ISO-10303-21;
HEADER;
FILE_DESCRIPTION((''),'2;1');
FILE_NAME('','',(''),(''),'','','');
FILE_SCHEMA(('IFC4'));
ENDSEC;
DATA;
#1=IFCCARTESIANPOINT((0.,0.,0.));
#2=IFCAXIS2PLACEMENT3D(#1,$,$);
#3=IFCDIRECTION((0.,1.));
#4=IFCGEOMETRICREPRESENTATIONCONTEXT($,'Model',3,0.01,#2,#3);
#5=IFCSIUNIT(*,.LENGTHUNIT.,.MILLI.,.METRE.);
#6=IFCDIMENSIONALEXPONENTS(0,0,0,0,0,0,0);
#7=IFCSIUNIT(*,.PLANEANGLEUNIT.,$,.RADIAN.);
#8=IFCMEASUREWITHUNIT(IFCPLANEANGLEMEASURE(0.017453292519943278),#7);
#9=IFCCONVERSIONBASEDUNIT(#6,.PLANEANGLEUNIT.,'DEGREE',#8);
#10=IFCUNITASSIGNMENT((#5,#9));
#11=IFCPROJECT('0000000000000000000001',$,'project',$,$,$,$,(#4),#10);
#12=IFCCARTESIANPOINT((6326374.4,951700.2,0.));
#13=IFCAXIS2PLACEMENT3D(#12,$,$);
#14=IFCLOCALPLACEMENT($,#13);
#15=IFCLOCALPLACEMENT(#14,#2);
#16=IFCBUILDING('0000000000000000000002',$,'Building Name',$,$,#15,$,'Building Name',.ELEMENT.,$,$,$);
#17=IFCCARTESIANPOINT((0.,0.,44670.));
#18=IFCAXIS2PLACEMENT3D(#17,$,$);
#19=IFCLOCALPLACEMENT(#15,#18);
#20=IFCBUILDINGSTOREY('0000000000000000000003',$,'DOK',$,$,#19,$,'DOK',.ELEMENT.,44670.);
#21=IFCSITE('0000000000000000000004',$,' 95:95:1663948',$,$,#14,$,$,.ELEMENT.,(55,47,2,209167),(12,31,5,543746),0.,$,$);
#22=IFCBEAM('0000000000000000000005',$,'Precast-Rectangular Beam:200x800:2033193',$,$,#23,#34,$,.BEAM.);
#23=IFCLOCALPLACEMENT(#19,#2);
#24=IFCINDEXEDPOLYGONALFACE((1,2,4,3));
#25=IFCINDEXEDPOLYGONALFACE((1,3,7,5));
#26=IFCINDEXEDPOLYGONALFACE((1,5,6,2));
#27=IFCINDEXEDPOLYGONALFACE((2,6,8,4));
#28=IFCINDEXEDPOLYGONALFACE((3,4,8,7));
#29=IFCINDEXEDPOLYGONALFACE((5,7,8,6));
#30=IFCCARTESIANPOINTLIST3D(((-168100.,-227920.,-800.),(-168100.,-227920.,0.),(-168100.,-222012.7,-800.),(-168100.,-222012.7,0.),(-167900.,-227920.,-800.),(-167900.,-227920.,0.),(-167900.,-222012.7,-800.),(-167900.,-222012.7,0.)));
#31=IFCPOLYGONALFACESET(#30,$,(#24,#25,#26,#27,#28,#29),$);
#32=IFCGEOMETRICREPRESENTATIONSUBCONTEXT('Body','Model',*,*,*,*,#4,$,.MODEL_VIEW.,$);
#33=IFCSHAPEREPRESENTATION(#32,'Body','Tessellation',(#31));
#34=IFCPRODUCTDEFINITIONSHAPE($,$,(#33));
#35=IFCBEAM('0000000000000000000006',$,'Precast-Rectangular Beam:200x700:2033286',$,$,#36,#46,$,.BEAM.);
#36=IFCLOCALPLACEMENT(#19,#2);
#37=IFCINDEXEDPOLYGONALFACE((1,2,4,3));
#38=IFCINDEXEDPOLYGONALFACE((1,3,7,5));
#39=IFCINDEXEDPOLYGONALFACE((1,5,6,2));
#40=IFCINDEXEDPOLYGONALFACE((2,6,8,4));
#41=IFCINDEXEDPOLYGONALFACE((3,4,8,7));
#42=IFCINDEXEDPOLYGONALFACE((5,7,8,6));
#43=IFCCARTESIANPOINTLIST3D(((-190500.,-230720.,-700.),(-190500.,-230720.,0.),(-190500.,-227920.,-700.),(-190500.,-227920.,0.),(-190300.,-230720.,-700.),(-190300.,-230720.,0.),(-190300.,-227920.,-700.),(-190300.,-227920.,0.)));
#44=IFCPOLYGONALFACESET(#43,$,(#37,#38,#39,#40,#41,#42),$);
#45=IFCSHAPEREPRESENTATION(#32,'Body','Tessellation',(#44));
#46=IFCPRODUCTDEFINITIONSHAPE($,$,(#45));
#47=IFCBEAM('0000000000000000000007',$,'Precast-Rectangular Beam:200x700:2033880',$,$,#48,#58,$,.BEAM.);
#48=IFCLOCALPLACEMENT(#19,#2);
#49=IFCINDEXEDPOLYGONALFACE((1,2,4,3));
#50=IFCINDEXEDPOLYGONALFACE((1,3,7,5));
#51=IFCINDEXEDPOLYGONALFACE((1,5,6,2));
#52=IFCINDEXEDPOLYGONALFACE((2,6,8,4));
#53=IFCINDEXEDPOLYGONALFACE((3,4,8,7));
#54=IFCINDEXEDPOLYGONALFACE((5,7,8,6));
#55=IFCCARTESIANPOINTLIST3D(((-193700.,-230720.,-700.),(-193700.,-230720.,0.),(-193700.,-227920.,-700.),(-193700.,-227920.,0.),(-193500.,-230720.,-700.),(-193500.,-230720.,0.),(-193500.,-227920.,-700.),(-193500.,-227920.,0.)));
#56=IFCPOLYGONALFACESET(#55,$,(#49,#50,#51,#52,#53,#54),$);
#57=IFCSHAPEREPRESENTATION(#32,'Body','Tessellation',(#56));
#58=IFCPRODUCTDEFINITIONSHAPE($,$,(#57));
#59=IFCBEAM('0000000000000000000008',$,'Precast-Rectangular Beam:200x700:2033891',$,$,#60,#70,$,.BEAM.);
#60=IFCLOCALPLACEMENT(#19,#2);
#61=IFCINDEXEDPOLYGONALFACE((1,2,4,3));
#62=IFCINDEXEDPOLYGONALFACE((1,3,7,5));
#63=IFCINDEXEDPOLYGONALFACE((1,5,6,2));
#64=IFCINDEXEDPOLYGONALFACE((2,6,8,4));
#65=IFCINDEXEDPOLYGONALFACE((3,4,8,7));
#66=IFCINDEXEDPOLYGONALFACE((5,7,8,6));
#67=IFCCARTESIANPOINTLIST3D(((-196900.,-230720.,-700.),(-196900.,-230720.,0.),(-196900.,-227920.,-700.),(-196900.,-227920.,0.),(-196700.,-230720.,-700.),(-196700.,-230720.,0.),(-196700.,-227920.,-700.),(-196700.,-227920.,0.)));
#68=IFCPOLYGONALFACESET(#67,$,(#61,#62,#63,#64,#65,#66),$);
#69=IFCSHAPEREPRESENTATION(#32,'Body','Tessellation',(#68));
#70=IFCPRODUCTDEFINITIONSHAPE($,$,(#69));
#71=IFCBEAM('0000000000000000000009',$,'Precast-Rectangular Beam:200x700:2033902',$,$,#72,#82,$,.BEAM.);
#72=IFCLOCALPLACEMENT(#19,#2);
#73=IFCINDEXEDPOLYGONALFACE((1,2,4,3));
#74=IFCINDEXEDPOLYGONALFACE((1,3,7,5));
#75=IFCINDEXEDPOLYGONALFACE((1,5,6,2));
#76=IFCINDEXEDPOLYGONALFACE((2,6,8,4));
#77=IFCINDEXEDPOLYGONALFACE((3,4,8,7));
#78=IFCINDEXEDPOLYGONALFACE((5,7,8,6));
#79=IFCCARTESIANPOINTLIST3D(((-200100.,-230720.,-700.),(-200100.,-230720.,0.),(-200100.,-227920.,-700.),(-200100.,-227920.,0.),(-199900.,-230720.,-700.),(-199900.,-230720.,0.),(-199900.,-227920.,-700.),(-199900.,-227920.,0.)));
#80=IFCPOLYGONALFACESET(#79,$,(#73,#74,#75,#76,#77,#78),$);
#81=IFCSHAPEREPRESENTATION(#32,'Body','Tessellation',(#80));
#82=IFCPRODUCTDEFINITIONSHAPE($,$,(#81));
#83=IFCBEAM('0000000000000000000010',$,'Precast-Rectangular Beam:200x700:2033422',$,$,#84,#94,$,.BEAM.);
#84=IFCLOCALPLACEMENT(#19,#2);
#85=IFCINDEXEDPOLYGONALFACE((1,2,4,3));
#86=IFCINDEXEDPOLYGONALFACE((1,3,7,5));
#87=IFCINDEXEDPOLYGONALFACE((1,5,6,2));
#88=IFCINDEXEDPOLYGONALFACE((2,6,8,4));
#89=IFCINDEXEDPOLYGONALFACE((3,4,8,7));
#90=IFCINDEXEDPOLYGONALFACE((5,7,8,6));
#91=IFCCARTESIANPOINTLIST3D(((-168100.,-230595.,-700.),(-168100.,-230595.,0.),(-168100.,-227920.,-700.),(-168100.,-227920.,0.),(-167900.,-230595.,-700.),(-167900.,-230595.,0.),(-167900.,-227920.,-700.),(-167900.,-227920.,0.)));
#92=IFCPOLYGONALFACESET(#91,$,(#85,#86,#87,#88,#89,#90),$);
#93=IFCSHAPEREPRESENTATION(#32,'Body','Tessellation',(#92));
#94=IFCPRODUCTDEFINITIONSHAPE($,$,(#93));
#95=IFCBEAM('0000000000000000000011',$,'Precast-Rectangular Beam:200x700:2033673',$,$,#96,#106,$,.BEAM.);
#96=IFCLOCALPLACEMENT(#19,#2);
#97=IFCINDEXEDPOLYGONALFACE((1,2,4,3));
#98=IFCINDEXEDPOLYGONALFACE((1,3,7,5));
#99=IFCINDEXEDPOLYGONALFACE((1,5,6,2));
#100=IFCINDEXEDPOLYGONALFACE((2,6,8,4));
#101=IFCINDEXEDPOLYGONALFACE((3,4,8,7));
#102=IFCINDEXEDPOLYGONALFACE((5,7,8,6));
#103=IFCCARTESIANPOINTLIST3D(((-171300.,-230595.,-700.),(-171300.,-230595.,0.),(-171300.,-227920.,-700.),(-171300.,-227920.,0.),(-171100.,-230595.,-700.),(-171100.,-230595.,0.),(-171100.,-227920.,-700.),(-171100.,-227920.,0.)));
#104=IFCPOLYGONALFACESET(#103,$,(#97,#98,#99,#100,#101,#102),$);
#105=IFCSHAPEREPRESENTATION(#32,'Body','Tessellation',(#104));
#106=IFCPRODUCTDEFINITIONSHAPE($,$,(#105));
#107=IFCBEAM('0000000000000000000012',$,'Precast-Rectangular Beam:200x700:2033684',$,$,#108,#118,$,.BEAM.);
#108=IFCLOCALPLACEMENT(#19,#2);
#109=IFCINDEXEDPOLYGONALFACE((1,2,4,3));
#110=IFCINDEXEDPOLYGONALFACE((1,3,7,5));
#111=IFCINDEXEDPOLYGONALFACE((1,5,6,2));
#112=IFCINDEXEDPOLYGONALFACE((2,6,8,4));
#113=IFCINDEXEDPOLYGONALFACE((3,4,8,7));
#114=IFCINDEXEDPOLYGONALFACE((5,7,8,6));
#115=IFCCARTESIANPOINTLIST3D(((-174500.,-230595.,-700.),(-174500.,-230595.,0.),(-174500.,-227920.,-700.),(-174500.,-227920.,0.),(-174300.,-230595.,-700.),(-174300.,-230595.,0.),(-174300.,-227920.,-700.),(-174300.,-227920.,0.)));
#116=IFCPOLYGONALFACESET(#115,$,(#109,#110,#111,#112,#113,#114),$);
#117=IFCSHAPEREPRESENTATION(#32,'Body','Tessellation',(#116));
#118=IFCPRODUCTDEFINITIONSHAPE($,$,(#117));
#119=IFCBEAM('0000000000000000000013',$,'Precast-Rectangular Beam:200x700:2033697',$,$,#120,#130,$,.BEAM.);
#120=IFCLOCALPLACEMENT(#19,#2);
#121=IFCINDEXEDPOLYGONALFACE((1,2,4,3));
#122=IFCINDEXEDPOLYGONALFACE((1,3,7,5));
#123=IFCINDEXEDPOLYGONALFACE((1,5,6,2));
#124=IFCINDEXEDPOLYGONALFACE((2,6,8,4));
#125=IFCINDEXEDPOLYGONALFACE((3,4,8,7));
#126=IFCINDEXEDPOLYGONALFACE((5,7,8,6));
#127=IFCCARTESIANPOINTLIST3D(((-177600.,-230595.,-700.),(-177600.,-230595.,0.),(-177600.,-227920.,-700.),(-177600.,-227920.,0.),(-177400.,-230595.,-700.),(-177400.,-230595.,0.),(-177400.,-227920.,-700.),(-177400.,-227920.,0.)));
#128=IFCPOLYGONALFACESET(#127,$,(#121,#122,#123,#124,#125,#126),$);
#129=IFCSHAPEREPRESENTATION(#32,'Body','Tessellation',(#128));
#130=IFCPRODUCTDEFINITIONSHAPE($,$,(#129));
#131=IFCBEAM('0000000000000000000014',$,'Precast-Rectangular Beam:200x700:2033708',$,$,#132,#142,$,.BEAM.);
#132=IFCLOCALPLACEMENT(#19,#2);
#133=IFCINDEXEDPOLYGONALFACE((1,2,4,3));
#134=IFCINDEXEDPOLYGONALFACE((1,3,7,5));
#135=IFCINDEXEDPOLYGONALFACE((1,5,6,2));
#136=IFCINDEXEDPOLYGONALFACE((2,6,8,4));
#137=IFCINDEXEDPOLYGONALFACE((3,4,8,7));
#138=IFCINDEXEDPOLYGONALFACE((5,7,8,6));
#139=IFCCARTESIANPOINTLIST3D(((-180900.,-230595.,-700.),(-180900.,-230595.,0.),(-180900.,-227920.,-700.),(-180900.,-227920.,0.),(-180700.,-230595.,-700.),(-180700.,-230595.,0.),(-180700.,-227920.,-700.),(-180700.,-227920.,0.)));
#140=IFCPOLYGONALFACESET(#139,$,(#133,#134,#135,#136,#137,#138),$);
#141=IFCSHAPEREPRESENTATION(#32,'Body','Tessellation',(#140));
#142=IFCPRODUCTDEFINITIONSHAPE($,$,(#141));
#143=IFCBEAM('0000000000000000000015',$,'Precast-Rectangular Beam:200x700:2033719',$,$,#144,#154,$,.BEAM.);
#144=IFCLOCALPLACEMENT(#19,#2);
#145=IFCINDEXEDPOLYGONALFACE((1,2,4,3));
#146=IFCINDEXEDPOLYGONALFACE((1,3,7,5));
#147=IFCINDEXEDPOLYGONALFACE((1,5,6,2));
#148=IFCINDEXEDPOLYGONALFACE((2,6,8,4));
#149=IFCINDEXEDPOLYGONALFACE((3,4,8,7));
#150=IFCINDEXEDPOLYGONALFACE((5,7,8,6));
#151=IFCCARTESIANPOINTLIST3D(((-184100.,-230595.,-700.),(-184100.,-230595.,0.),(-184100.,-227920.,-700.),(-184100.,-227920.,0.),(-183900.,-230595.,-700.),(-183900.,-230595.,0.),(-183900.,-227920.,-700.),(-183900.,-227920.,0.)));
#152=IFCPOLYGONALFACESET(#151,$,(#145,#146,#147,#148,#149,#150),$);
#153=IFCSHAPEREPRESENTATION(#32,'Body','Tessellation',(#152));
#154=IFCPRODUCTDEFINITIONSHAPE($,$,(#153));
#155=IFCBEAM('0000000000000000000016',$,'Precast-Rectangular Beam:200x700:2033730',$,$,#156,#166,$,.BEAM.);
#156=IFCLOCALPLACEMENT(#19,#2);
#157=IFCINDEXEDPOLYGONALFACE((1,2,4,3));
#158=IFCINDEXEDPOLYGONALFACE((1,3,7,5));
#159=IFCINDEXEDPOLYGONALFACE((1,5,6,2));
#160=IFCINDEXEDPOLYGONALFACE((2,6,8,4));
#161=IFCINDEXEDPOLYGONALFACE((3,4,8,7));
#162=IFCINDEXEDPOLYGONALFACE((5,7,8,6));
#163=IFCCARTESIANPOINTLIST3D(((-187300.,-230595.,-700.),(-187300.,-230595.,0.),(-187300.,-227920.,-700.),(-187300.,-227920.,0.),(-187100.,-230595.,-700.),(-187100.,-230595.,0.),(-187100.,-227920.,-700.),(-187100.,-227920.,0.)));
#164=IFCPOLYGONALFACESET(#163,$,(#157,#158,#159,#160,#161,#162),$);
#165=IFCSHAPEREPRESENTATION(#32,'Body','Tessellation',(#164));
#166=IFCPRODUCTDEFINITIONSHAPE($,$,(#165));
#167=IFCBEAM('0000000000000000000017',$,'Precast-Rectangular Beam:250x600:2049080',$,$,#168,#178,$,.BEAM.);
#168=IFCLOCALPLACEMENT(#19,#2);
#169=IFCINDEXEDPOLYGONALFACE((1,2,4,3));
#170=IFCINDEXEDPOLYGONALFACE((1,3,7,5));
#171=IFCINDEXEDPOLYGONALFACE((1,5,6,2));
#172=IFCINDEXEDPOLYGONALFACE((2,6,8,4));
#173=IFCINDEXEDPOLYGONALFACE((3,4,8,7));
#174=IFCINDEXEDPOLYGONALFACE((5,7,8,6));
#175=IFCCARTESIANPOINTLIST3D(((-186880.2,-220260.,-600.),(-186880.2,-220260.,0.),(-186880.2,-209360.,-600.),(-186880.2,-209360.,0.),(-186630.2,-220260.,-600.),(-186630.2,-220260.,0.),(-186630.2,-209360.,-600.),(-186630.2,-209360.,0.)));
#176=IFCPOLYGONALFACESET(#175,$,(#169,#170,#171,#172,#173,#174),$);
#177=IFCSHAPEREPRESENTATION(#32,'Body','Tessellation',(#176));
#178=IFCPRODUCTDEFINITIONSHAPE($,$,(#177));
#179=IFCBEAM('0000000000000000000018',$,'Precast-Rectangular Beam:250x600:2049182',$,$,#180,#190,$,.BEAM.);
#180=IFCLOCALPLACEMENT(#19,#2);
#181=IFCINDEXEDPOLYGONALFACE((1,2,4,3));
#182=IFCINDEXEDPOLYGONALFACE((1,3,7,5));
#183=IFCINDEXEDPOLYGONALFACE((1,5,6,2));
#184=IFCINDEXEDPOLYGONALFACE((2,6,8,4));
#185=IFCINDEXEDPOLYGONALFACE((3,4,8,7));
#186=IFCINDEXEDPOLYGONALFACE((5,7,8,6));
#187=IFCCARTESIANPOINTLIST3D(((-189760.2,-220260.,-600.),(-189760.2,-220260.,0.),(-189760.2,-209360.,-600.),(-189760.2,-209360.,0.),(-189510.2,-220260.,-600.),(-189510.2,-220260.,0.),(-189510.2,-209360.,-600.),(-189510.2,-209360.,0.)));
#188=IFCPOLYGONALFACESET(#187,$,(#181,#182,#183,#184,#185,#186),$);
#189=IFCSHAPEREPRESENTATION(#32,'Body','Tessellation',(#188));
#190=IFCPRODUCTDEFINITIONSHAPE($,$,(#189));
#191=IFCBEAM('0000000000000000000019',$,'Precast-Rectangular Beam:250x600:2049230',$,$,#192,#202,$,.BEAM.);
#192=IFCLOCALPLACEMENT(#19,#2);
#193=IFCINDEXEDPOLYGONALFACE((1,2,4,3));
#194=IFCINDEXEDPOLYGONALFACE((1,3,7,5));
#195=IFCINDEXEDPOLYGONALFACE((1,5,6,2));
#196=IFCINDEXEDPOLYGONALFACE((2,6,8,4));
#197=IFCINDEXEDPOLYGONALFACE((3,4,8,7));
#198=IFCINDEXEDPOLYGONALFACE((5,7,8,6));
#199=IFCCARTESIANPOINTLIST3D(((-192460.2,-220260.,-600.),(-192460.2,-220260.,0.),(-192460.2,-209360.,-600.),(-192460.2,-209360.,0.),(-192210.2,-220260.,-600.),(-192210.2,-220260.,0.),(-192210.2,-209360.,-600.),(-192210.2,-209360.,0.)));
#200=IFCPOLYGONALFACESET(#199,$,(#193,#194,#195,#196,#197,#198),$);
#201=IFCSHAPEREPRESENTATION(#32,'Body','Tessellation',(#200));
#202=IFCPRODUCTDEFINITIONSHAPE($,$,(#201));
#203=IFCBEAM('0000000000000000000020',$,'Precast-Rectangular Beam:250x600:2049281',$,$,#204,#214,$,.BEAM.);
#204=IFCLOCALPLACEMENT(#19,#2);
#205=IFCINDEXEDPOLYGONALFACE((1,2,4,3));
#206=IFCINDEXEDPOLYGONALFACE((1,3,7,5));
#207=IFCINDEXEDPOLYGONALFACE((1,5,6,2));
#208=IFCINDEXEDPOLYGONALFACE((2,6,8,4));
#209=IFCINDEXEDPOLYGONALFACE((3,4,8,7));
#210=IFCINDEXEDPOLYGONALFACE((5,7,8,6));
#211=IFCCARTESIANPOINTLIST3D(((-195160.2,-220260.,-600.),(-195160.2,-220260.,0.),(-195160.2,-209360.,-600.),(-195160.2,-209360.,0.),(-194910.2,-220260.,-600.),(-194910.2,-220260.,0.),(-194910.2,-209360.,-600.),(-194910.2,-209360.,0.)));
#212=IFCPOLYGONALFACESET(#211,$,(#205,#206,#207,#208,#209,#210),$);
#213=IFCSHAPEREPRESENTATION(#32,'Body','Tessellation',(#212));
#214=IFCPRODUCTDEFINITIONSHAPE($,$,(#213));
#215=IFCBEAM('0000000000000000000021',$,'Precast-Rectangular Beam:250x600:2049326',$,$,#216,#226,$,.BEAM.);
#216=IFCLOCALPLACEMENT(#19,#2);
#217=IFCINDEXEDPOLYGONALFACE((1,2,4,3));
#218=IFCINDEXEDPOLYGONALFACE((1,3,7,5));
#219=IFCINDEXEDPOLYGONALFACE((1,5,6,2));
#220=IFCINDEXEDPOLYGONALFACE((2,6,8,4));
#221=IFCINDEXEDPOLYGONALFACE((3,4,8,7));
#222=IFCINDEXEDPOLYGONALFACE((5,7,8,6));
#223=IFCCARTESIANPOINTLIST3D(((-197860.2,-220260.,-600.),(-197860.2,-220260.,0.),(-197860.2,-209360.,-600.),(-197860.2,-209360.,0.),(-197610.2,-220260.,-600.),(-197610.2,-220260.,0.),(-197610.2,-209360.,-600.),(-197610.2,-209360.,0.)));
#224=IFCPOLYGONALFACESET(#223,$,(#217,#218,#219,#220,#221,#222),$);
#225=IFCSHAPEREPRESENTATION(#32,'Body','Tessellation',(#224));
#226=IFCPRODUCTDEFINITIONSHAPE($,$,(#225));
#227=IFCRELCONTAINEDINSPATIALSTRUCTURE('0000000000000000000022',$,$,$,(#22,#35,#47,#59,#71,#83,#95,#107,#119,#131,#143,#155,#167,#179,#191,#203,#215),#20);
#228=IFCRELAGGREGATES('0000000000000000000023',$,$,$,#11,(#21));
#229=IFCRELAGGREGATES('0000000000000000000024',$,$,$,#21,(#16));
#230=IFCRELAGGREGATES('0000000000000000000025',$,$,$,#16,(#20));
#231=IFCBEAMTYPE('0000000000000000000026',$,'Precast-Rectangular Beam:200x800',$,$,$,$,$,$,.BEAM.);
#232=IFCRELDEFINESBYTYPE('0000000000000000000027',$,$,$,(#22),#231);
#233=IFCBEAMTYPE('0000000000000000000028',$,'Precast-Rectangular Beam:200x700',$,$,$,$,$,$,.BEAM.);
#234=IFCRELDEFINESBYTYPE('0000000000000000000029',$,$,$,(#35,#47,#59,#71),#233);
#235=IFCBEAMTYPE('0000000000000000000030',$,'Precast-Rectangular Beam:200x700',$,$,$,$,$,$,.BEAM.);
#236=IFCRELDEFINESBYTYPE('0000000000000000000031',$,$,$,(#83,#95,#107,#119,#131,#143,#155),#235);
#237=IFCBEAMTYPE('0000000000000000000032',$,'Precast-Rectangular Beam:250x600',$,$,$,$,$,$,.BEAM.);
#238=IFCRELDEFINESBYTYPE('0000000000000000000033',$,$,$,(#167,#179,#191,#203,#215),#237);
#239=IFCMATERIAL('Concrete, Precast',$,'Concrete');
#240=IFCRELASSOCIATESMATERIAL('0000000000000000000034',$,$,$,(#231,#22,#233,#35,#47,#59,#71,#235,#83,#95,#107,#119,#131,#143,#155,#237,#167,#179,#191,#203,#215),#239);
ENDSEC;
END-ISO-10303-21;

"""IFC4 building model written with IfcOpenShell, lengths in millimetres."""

from ifc_helpers import new_model, entity, si_unit, converted_unit, direction, frame, origin, place, context, subcontext, project, spatial, indexed_curve, outline, extrude, source, transform, mapped, material, type_object, type_shapes, element, save


model = new_model("IFC4")

# Units and contexts
model_context = context("Model", 3, precision=0.01, world=origin(), true_north=direction((0.0, 1.0)))
body_context = subcontext(model_context, "Body", "Model", "MODEL_VIEW")
ifc_project = project(units=[si_unit("LENGTHUNIT", "METRE", prefix="MILLI"), converted_unit("PLANEANGLEUNIT", "DEGREE", entity("IfcPlaneAngleMeasure", 0.017453292519943278), si_unit("PLANEANGLEUNIT", "RADIAN"), dimensions=[0, 0, 0, 0, 0, 0, 0])], contexts=[model_context])

# Site, building, storey
site_placement = place(None, frame((6326374.4, 951700.2, 0.0)))
site = spatial("IfcSite", under=ifc_project, at=site_placement, Name=" 95:95:1663948", CompositionType="ELEMENT", RefLatitude=(55, 47, 2, 209167), RefLongitude=(12, 31, 5, 543746), RefElevation=0.0)
building_placement = place(site_placement, origin())
building = spatial("IfcBuilding", under=site, at=building_placement, Name="Building Name", LongName="Building Name", CompositionType="ELEMENT")
storey_placement = place(building_placement, frame((0.0, 0.0, 44670.0)))
storey = spatial("IfcBuildingStorey", under=building, at=storey_placement, Name="DOK", LongName="DOK", CompositionType="ELEMENT", Elevation=44670.0)

# Beams
ifc_material = material(Name="Concrete, Precast", Category="Concrete")
beam_type_1 = type_object("IfcBeamType", Name="Precast-Rectangular Beam:200x800", PredefinedType="BEAM", material=ifc_material)
shared_shape_1 = source(origin(), body_context, "Body", "SweptSolid", [
    extrude(outline(indexed_curve([(-2953.7, -100.0), (2953.7, -100.0), (2953.7, 100.0), (-2953.7, 100.0), (-2953.7, -100.0)], self_intersect=False)), frame((-66.4, 0.0, -400.0), z_axis=(0.0, 0.0, 1.0), x_axis=(-1.0, 0.0, 0.0)), (0.0, 0.0, 1.0), 800.0),
])
type_shapes(beam_type_1, [shared_shape_1])
beam_1_placement = place(storey_placement, frame((-168000.0, -224900.0, -400.0), z_axis=(0.0, 0.0, 1.0), x_axis=(0.0, 1.0, 0.0)))
element("IfcBeam", 1, at=beam_1_placement, inside=storey, type_object=beam_type_1, material=ifc_material, Name="Precast-Rectangular Beam:200x800:2033193", PredefinedType="BEAM", context=body_context, shape_type="MappedRepresentation", body=[
    mapped(shared_shape_1, transform((0.0, 0.0, 0.0), scale=1.0)),
])
beam_type_2 = type_object("IfcBeamType", Name="Precast-Rectangular Beam:200x700", PredefinedType="BEAM", material=ifc_material)
shared_shape_2 = source(origin(), body_context, "Body", "SweptSolid", [
    extrude(outline(indexed_curve([(-1400.0, -100.0), (1400.0, -100.0), (1400.0, 100.0), (-1400.0, 100.0), (-1400.0, -100.0)], self_intersect=False)), frame((0.0, 0.0, -350.0), z_axis=(0.0, 0.0, 1.0), x_axis=(-1.0, 0.0, 0.0)), (0.0, 0.0, 1.0), 700.0),
])
type_shapes(beam_type_2, [shared_shape_2])
for number, where, z_axis, x_axis, name in (
    (2, (-190400.0, -229320.0, -350.0), (0.0, 0.0, 1.0), (0.0, -1.0, 0.0), "Precast-Rectangular Beam:200x700:2033286"),
    (3, (-193600.0, -229320.0, -350.0), (0.0, 0.0, 1.0), (0.0, -1.0, 0.0), "Precast-Rectangular Beam:200x700:2033880"),
    (4, (-196800.0, -229320.0, -350.0), (0.0, 0.0, 1.0), (0.0, -1.0, 0.0), "Precast-Rectangular Beam:200x700:2033891"),
    (5, (-200000.0, -229320.0, -350.0), (0.0, 0.0, 1.0), (0.0, -1.0, 0.0), "Precast-Rectangular Beam:200x700:2033902"),
):
    element("IfcBeam", number, at=place(storey_placement, frame(where, z_axis=z_axis, x_axis=x_axis)), inside=storey, type_object=beam_type_2, material=ifc_material, Name=name, PredefinedType="BEAM", context=body_context, shape_type="MappedRepresentation", body=[
        mapped(shared_shape_2, transform((0.0, 0.0, 0.0), scale=1.0)),
    ])
beam_type_3 = type_object("IfcBeamType", Name="Precast-Rectangular Beam:200x700", PredefinedType="BEAM", material=ifc_material)
shared_shape_3 = source(origin(), body_context, "Body", "SweptSolid", [
    extrude(outline(indexed_curve([(-1337.5, -100.0), (1337.5, -100.0), (1337.5, 100.0), (-1337.5, 100.0), (-1337.5, -100.0)], self_intersect=False)), frame((0.0, 0.0, -350.0), z_axis=(0.0, 0.0, 1.0), x_axis=(-1.0, 0.0, 0.0)), (0.0, 0.0, 1.0), 700.0),
])
type_shapes(beam_type_3, [shared_shape_3])
for number, where, z_axis, x_axis, name in (
    (6, (-168000.0, -229257.5, -350.0), (0.0, 0.0, 1.0), (0.0, -1.0, 0.0), "Precast-Rectangular Beam:200x700:2033422"),
    (7, (-171200.0, -229257.5, -350.0), (0.0, 0.0, 1.0), (0.0, -1.0, 0.0), "Precast-Rectangular Beam:200x700:2033673"),
    (8, (-174400.0, -229257.5, -350.0), (0.0, 0.0, 1.0), (0.0, -1.0, 0.0), "Precast-Rectangular Beam:200x700:2033684"),
    (9, (-177500.0, -229257.5, -350.0), (0.0, 0.0, 1.0), (0.0, -1.0, 0.0), "Precast-Rectangular Beam:200x700:2033697"),
    (10, (-180800.0, -229257.5, -350.0), (0.0, 0.0, 1.0), (0.0, -1.0, 0.0), "Precast-Rectangular Beam:200x700:2033708"),
    (11, (-184000.0, -229257.5, -350.0), (0.0, 0.0, 1.0), (0.0, -1.0, 0.0), "Precast-Rectangular Beam:200x700:2033719"),
    (12, (-187200.0, -229257.5, -350.0), (0.0, 0.0, 1.0), (0.0, -1.0, 0.0), "Precast-Rectangular Beam:200x700:2033730"),
):
    element("IfcBeam", number, at=place(storey_placement, frame(where, z_axis=z_axis, x_axis=x_axis)), inside=storey, type_object=beam_type_3, material=ifc_material, Name=name, PredefinedType="BEAM", context=body_context, shape_type="MappedRepresentation", body=[
        mapped(shared_shape_3, transform((0.0, 0.0, 0.0), scale=1.0)),
    ])
beam_type_4 = type_object("IfcBeamType", Name="Precast-Rectangular Beam:250x600", PredefinedType="BEAM", material=ifc_material)
shared_shape_4 = source(origin(), body_context, "Body", "SweptSolid", [
    extrude(outline(indexed_curve([(-5450.0, -125.0), (5450.0, -125.0), (5450.0, 125.0), (-5450.0, 125.0), (-5450.0, -125.0)], self_intersect=False)), frame((0.0, 0.0, -300.0), z_axis=(0.0, 0.0, 1.0), x_axis=(-1.0, 0.0, 0.0)), (0.0, 0.0, 1.0), 600.0),
])
type_shapes(beam_type_4, [shared_shape_4])
for number, where, z_axis, x_axis, name in (
    (13, (-186755.2, -214810.0, -300.0), (0.0, 0.0, 1.0), (0.0, 1.0, 0.0), "Precast-Rectangular Beam:250x600:2049080"),
    (14, (-189635.2, -214810.0, -300.0), (0.0, 0.0, 1.0), (0.0, 1.0, 0.0), "Precast-Rectangular Beam:250x600:2049182"),
    (15, (-192335.2, -214810.0, -300.0), (0.0, 0.0, 1.0), (0.0, 1.0, 0.0), "Precast-Rectangular Beam:250x600:2049230"),
    (16, (-195035.2, -214810.0, -300.0), (0.0, 0.0, 1.0), (0.0, 1.0, 0.0), "Precast-Rectangular Beam:250x600:2049281"),
    (17, (-197735.2, -214810.0, -300.0), (0.0, 0.0, 1.0), (0.0, 1.0, 0.0), "Precast-Rectangular Beam:250x600:2049326"),
):
    element("IfcBeam", number, at=place(storey_placement, frame(where, z_axis=z_axis, x_axis=x_axis)), inside=storey, type_object=beam_type_4, material=ifc_material, Name=name, PredefinedType="BEAM", context=body_context, shape_type="MappedRepresentation", body=[
        mapped(shared_shape_4, transform((0.0, 0.0, 0.0), scale=1.0)),
    ])

save(model, "model.ifc")
